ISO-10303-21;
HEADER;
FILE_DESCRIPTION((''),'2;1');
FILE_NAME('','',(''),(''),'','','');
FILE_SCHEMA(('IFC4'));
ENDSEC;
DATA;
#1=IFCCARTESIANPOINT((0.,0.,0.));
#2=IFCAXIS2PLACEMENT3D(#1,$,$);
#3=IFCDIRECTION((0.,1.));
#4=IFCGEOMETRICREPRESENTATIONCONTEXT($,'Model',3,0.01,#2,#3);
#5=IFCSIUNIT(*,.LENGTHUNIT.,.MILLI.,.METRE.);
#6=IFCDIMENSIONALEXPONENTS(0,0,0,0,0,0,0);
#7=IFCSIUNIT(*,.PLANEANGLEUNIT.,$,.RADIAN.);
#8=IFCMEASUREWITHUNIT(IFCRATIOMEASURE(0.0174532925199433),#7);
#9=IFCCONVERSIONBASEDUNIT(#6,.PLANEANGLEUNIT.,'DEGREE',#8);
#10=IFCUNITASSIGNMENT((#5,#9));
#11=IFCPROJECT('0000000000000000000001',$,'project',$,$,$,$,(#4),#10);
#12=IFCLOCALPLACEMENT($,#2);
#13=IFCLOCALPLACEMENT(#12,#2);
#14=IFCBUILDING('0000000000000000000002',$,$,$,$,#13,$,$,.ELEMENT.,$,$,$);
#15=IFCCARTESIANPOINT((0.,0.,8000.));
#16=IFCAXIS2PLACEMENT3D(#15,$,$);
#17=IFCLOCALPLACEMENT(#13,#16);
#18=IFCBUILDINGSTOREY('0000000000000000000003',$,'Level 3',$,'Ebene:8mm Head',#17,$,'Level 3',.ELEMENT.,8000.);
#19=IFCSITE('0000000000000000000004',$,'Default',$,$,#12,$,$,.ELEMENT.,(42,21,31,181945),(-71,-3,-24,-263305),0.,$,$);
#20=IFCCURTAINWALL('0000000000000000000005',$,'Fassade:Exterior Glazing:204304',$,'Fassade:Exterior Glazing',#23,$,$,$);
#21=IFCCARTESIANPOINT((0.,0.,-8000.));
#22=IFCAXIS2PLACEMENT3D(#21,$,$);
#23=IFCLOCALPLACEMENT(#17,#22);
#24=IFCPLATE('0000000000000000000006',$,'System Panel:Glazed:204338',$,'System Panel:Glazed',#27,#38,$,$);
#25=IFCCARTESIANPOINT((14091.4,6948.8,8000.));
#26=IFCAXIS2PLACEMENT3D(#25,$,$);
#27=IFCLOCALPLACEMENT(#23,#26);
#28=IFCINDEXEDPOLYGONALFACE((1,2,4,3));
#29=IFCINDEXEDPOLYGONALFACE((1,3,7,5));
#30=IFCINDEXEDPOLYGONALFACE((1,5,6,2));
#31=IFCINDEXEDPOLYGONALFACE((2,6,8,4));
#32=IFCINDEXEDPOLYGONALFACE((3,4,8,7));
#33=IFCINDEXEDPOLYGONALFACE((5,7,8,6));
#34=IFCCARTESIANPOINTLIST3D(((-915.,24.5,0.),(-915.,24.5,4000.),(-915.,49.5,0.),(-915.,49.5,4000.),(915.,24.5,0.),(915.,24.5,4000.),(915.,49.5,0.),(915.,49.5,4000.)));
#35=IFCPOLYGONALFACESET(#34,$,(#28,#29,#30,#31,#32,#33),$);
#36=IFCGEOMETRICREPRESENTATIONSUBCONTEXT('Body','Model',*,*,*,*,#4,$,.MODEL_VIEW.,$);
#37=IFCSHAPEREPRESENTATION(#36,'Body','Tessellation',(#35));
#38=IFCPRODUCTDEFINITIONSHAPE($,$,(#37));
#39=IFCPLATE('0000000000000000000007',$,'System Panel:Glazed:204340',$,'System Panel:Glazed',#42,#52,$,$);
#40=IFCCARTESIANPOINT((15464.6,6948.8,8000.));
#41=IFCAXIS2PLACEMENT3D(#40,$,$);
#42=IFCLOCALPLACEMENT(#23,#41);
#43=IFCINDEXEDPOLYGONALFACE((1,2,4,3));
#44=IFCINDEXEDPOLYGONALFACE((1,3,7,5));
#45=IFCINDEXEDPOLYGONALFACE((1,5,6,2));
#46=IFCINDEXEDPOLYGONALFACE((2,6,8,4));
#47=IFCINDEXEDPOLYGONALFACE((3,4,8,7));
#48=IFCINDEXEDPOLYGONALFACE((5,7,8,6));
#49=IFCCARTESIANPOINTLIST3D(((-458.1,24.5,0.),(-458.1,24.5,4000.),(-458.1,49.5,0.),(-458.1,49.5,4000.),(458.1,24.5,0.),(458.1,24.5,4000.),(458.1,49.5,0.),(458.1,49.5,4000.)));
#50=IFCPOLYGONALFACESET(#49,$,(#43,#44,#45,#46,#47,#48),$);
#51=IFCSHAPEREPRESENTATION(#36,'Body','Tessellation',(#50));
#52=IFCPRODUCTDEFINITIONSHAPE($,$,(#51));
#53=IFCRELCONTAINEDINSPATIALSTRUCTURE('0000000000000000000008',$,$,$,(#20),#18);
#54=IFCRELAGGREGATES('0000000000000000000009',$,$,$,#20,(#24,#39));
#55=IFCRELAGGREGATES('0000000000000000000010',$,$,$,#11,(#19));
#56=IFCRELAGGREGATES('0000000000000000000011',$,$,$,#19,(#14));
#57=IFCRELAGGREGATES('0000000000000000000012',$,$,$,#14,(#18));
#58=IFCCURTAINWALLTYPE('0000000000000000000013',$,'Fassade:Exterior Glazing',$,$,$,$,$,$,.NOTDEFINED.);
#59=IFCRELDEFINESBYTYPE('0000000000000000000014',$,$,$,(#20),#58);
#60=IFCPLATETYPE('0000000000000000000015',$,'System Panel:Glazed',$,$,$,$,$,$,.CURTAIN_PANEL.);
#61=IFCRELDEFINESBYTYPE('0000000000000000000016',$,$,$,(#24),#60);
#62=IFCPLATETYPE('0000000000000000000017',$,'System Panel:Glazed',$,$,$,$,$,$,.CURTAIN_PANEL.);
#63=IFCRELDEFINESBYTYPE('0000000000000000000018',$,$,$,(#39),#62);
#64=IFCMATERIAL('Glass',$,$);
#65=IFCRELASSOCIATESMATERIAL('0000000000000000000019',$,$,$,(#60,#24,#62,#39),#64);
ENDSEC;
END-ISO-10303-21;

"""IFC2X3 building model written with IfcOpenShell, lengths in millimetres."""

from ifc_helpers import new_model, entity, si_unit, converted_unit, direction, frame, origin, origin_2d_with_axis, place, context, subcontext, project, spatial, rectangle, extrude, source, transform, mapped, material, type_object, type_shapes, element, aggregate, save


model = new_model("IFC2X3")

# Units and contexts
model_context = context("Model", 3, precision=0.01, world=origin(), true_north=direction((0.0, 1.0)))
body_context = subcontext(model_context, "Body", "Model", "MODEL_VIEW")
ifc_project = project(units=[si_unit("LENGTHUNIT", "METRE", prefix="MILLI"), converted_unit("PLANEANGLEUNIT", "DEGREE", entity("IfcRatioMeasure", 0.0174532925199433), si_unit("PLANEANGLEUNIT", "RADIAN"), dimensions=[0, 0, 0, 0, 0, 0, 0])], contexts=[model_context])

# Site, building, storey
site_placement = place(None, origin())
site = spatial("IfcSite", under=ifc_project, at=site_placement, Name="Default", CompositionType="ELEMENT", RefLatitude=(42, 21, 31, 181945), RefLongitude=(-71, -3, -24, -263305), RefElevation=0.0)
building_placement = place(site_placement, origin())
building = spatial("IfcBuilding", under=site, at=building_placement, CompositionType="ELEMENT")
storey_placement = place(building_placement, frame((0.0, 0.0, 8000.0)))
storey = spatial("IfcBuildingStorey", under=building, at=storey_placement, Name="Level 3", ObjectType="Ebene:8mm Head", LongName="Level 3", CompositionType="ELEMENT", Elevation=8000.0)

# Curtain wall, plates
curtain_wall_type = type_object("IfcCurtainWallType", Name="Fassade:Exterior Glazing", PredefinedType="NOTDEFINED")
curtain_wall_placement = place(storey_placement, frame((0.0, 0.0, -8000.0)))
curtain_wall = element("IfcCurtainWall", 1, at=curtain_wall_placement, inside=storey, type_object=curtain_wall_type, Name="Fassade:Exterior Glazing:204304", ObjectType="Fassade:Exterior Glazing")
ifc_material_1 = material(Name="Glass")
plate_type_1 = type_object("IfcPlateType", Name="System Panel:Glazed", PredefinedType="CURTAIN_PANEL", material=ifc_material_1)
shared_shape_1 = source(origin(), body_context, "Body", "SweptSolid", [
    extrude(rectangle(XDim=25.0, YDim=1830.0, at=origin_2d_with_axis()), frame((0.0, 37.0, 0.0), z_axis=(0.0, 0.0, 1.0), x_axis=(0.0, 1.0, 0.0)), (0.0, 0.0, 1.0), 4000.0),
])
type_shapes(plate_type_1, [shared_shape_1])
plate_1_placement = place(curtain_wall_placement, frame((14091.4, 6948.8, 8000.0)))
plate_1 = element("IfcPlate", 2, at=plate_1_placement, type_object=plate_type_1, material=ifc_material_1, Name="System Panel:Glazed:204338", ObjectType="System Panel:Glazed", context=body_context, shape_type="MappedRepresentation", body=[
    mapped(shared_shape_1, transform((0.0, 0.0, 0.0), scale=1.0)),
])
plate_type_2 = type_object("IfcPlateType", Name="System Panel:Glazed", PredefinedType="CURTAIN_PANEL", material=ifc_material_1)
shared_shape_2 = source(origin(), body_context, "Body", "SweptSolid", [
    extrude(rectangle(XDim=25.0, YDim=916.3, at=origin_2d_with_axis()), frame((0.0, 37.0, 0.0), z_axis=(0.0, 0.0, 1.0), x_axis=(0.0, 1.0, 0.0)), (0.0, 0.0, 1.0), 4000.0),
])
type_shapes(plate_type_2, [shared_shape_2])
plate_2_placement = place(curtain_wall_placement, frame((15464.6, 6948.8, 8000.0)))
plate_2 = element("IfcPlate", 3, at=plate_2_placement, type_object=plate_type_2, material=ifc_material_1, Name="System Panel:Glazed:204340", ObjectType="System Panel:Glazed", context=body_context, shape_type="MappedRepresentation", body=[
    mapped(shared_shape_2, transform((0.0, 0.0, 0.0), scale=1.0)),
])
aggregate(curtain_wall, [plate_1, plate_2])

save(model, "model.ifc")
